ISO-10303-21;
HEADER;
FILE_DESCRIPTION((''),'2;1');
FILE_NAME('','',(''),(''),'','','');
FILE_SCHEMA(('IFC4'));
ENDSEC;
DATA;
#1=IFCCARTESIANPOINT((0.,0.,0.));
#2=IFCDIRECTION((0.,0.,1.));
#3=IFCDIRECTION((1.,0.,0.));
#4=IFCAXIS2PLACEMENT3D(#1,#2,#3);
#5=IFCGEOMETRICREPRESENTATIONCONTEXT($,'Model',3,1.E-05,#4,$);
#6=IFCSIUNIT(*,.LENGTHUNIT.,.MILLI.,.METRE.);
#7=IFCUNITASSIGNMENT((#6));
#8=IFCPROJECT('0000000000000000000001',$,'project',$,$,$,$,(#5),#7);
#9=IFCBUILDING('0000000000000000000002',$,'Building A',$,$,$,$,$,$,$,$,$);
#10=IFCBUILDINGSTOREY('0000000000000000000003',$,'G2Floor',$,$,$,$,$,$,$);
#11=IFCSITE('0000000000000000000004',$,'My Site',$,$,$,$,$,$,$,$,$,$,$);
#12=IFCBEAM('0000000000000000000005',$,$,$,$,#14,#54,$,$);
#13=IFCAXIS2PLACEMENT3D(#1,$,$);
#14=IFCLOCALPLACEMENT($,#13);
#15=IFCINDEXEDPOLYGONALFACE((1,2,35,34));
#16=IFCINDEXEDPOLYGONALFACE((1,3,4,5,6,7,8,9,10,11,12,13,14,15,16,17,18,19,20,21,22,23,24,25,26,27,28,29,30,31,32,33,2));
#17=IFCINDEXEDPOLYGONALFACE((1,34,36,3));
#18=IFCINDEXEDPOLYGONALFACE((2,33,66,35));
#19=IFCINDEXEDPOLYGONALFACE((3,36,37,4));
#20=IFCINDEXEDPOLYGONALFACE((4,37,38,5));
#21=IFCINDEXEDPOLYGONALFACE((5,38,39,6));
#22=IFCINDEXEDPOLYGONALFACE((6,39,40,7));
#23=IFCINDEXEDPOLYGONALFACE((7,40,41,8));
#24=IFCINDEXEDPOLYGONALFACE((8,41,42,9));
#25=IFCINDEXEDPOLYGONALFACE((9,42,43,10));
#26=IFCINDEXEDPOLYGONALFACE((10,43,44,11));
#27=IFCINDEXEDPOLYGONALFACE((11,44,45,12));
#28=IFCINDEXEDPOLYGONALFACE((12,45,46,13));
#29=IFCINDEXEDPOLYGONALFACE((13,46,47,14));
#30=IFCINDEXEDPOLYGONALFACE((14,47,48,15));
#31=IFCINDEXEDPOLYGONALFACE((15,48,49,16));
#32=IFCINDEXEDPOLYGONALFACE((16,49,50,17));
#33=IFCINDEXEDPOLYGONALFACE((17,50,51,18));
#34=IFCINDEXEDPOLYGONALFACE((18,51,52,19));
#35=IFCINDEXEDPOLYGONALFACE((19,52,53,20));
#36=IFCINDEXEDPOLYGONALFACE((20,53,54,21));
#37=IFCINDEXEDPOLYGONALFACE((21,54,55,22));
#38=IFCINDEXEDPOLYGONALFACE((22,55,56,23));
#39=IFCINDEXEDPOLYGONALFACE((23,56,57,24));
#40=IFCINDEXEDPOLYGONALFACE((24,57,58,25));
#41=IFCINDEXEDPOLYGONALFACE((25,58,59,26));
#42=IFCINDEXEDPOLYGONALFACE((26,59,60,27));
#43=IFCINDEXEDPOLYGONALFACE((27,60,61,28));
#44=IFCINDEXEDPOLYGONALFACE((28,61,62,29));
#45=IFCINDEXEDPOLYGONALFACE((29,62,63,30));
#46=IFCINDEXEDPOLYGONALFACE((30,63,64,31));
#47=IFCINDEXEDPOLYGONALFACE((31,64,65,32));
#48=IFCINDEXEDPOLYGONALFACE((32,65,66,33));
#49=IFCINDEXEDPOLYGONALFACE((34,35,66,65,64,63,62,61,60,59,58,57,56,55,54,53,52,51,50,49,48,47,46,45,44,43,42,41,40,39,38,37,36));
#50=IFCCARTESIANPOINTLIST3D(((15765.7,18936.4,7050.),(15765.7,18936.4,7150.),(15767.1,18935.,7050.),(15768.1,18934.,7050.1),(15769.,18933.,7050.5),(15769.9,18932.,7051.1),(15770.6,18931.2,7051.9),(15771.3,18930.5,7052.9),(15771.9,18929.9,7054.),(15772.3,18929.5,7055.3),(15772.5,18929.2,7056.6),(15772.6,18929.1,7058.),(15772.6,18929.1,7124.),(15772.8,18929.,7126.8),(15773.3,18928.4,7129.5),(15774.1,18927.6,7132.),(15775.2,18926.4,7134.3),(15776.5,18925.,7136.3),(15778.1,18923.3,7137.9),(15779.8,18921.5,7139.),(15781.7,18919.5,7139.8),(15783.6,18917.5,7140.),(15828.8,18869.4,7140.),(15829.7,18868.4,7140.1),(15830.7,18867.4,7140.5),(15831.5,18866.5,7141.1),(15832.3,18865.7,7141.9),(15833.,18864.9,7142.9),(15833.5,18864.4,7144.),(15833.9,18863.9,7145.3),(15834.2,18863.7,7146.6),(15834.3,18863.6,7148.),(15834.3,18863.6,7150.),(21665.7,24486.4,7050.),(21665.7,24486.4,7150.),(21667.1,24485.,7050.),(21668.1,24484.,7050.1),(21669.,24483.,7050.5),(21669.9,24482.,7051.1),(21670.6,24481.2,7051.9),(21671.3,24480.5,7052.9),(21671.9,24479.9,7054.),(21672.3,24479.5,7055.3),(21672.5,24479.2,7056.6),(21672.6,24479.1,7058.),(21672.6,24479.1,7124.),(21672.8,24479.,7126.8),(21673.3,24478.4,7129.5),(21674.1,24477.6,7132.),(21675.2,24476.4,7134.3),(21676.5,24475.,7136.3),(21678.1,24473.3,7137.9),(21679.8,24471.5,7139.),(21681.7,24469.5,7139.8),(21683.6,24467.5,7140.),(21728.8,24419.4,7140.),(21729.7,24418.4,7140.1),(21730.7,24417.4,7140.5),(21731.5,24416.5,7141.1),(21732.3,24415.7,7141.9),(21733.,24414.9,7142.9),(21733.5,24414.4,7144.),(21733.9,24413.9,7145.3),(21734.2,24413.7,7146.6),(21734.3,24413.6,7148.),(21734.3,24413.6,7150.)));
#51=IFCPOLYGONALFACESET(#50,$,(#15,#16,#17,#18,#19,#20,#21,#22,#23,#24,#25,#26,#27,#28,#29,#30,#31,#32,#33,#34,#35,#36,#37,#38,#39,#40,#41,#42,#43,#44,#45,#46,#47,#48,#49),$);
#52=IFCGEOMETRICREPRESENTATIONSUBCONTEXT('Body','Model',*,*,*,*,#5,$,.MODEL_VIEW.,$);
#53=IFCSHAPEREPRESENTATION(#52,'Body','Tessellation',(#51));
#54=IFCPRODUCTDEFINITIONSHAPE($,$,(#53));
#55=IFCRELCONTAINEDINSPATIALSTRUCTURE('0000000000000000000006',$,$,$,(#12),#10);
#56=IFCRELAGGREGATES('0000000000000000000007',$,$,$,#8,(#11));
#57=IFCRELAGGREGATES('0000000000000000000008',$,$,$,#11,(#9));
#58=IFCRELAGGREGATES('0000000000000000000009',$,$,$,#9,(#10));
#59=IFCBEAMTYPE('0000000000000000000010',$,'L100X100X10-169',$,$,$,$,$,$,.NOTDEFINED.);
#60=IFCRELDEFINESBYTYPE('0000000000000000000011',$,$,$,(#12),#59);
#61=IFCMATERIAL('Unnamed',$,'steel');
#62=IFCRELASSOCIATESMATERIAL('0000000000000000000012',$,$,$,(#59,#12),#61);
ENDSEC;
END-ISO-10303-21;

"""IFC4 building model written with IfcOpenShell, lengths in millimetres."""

from ifc_helpers import new_model, si_unit, frame, origin_with_axes, place, context, subcontext, project, spatial, polyline, outline, extrude, material, material_profile, profile_set, profile_usage, type_object, element, save


model = new_model("IFC4")

# Units and contexts
model_context = context("Model", 3, precision=1e-05, world=origin_with_axes())
body_context = subcontext(model_context, "Body", "Model", "MODEL_VIEW")
ifc_project = project(units=[si_unit("LENGTHUNIT", "METRE", prefix="MILLI")], contexts=[model_context])

# Site, building, storey
site = spatial("IfcSite", under=ifc_project, Name="My Site")
building = spatial("IfcBuilding", under=site, Name="Building A")
storey = spatial("IfcBuildingStorey", under=building, Name="G2Floor")

# Beam
ifc_material_1 = material(Name="Unnamed", Category="steel")
ifc_material_profile_1 = material_profile(ifc_material_1, outline(polyline([(-50.0, -50.0), (50.0, -50.0), (50.0, -50.0), (50.0, -48.0), (50.0, -48.0), (49.9, -46.6), (49.9, -46.6), (49.5, -45.3), (49.5, -45.3), (48.9, -44.0), (48.9, -44.0), (48.1, -42.9), (48.1, -42.9), (47.1, -41.9), (47.1, -41.9), (46.0, -41.1), (46.0, -41.1), (44.7, -40.5), (44.7, -40.5), (43.4, -40.1), (43.4, -40.1), (42.0, -40.0), (42.0, -40.0), (-24.0, -40.0), (-24.0, -40.0), (-26.8, -39.8), (-26.8, -39.8), (-29.5, -39.0), (-29.5, -39.0), (-32.0, -37.9), (-32.0, -37.9), (-34.3, -36.3), (-34.3, -36.3), (-36.3, -34.3), (-36.3, -34.3), (-37.9, -32.0), (-37.9, -32.0), (-39.0, -29.5), (-39.0, -29.5), (-39.8, -26.8), (-39.8, -26.8), (-40.0, -24.0), (-40.0, -24.0), (-40.0, 42.0), (-40.0, 42.0), (-40.1, 43.4), (-40.1, 43.4), (-40.5, 44.7), (-40.5, 44.7), (-41.1, 46.0), (-41.1, 46.0), (-41.9, 47.1), (-41.9, 47.1), (-42.9, 48.1), (-42.9, 48.1), (-44.0, 48.9), (-44.0, 48.9), (-45.3, 49.5), (-45.3, 49.5), (-46.6, 49.9), (-46.6, 49.9), (-48.0, 50.0), (-48.0, 50.0), (-50.0, 50.0), (-50.0, 50.0), (-50.0, -50.0)])))
ifc_profile_set_1 = profile_set([ifc_material_profile_1], Name="L100X100X10-169")
ifc_profile_usage_1 = profile_usage(ifc_profile_set_1)
beam_type_1 = type_object("IfcBeamType", Name="L100X100X10-169", PredefinedType="NOTDEFINED", material=ifc_profile_set_1)
beam_1_placement = place(None, frame((15800.0, 18900.0, 7100.0), z_axis=(0.728381, 0.685172, 0.0), x_axis=(0.685172, -0.728381, 0.0)))
element("IfcBeam", 1, at=beam_1_placement, inside=storey, type_object=beam_type_1, material=ifc_profile_usage_1, context=body_context, shape_type="SweptSolid", body=[
    extrude(outline(polyline([(-50.0, -50.0), (50.0, -50.0), (50.0, -50.0), (50.0, -48.0), (50.0, -48.0), (49.9, -46.6), (49.9, -46.6), (49.5, -45.3), (49.5, -45.3), (48.9, -44.0), (48.9, -44.0), (48.1, -42.9), (48.1, -42.9), (47.1, -41.9), (47.1, -41.9), (46.0, -41.1), (46.0, -41.1), (44.7, -40.5), (44.7, -40.5), (43.4, -40.1), (43.4, -40.1), (42.0, -40.0), (42.0, -40.0), (-24.0, -40.0), (-24.0, -40.0), (-26.8, -39.8), (-26.8, -39.8), (-29.5, -39.0), (-29.5, -39.0), (-32.0, -37.9), (-32.0, -37.9), (-34.3, -36.3), (-34.3, -36.3), (-36.3, -34.3), (-36.3, -34.3), (-37.9, -32.0), (-37.9, -32.0), (-39.0, -29.5), (-39.0, -29.5), (-39.8, -26.8), (-39.8, -26.8), (-40.0, -24.0), (-40.0, -24.0), (-40.0, 42.0), (-40.0, 42.0), (-40.1, 43.4), (-40.1, 43.4), (-40.5, 44.7), (-40.5, 44.7), (-41.1, 46.0), (-41.1, 46.0), (-41.9, 47.1), (-41.9, 47.1), (-42.9, 48.1), (-42.9, 48.1), (-44.0, 48.9), (-44.0, 48.9), (-45.3, 49.5), (-45.3, 49.5), (-46.6, 49.9), (-46.6, 49.9), (-48.0, 50.0), (-48.0, 50.0), (-50.0, 50.0), (-50.0, 50.0), (-50.0, -50.0)])), origin_with_axes(), (0.0, 0.0, 1.0), 8100.2),
])

save(model, "model.ifc")
